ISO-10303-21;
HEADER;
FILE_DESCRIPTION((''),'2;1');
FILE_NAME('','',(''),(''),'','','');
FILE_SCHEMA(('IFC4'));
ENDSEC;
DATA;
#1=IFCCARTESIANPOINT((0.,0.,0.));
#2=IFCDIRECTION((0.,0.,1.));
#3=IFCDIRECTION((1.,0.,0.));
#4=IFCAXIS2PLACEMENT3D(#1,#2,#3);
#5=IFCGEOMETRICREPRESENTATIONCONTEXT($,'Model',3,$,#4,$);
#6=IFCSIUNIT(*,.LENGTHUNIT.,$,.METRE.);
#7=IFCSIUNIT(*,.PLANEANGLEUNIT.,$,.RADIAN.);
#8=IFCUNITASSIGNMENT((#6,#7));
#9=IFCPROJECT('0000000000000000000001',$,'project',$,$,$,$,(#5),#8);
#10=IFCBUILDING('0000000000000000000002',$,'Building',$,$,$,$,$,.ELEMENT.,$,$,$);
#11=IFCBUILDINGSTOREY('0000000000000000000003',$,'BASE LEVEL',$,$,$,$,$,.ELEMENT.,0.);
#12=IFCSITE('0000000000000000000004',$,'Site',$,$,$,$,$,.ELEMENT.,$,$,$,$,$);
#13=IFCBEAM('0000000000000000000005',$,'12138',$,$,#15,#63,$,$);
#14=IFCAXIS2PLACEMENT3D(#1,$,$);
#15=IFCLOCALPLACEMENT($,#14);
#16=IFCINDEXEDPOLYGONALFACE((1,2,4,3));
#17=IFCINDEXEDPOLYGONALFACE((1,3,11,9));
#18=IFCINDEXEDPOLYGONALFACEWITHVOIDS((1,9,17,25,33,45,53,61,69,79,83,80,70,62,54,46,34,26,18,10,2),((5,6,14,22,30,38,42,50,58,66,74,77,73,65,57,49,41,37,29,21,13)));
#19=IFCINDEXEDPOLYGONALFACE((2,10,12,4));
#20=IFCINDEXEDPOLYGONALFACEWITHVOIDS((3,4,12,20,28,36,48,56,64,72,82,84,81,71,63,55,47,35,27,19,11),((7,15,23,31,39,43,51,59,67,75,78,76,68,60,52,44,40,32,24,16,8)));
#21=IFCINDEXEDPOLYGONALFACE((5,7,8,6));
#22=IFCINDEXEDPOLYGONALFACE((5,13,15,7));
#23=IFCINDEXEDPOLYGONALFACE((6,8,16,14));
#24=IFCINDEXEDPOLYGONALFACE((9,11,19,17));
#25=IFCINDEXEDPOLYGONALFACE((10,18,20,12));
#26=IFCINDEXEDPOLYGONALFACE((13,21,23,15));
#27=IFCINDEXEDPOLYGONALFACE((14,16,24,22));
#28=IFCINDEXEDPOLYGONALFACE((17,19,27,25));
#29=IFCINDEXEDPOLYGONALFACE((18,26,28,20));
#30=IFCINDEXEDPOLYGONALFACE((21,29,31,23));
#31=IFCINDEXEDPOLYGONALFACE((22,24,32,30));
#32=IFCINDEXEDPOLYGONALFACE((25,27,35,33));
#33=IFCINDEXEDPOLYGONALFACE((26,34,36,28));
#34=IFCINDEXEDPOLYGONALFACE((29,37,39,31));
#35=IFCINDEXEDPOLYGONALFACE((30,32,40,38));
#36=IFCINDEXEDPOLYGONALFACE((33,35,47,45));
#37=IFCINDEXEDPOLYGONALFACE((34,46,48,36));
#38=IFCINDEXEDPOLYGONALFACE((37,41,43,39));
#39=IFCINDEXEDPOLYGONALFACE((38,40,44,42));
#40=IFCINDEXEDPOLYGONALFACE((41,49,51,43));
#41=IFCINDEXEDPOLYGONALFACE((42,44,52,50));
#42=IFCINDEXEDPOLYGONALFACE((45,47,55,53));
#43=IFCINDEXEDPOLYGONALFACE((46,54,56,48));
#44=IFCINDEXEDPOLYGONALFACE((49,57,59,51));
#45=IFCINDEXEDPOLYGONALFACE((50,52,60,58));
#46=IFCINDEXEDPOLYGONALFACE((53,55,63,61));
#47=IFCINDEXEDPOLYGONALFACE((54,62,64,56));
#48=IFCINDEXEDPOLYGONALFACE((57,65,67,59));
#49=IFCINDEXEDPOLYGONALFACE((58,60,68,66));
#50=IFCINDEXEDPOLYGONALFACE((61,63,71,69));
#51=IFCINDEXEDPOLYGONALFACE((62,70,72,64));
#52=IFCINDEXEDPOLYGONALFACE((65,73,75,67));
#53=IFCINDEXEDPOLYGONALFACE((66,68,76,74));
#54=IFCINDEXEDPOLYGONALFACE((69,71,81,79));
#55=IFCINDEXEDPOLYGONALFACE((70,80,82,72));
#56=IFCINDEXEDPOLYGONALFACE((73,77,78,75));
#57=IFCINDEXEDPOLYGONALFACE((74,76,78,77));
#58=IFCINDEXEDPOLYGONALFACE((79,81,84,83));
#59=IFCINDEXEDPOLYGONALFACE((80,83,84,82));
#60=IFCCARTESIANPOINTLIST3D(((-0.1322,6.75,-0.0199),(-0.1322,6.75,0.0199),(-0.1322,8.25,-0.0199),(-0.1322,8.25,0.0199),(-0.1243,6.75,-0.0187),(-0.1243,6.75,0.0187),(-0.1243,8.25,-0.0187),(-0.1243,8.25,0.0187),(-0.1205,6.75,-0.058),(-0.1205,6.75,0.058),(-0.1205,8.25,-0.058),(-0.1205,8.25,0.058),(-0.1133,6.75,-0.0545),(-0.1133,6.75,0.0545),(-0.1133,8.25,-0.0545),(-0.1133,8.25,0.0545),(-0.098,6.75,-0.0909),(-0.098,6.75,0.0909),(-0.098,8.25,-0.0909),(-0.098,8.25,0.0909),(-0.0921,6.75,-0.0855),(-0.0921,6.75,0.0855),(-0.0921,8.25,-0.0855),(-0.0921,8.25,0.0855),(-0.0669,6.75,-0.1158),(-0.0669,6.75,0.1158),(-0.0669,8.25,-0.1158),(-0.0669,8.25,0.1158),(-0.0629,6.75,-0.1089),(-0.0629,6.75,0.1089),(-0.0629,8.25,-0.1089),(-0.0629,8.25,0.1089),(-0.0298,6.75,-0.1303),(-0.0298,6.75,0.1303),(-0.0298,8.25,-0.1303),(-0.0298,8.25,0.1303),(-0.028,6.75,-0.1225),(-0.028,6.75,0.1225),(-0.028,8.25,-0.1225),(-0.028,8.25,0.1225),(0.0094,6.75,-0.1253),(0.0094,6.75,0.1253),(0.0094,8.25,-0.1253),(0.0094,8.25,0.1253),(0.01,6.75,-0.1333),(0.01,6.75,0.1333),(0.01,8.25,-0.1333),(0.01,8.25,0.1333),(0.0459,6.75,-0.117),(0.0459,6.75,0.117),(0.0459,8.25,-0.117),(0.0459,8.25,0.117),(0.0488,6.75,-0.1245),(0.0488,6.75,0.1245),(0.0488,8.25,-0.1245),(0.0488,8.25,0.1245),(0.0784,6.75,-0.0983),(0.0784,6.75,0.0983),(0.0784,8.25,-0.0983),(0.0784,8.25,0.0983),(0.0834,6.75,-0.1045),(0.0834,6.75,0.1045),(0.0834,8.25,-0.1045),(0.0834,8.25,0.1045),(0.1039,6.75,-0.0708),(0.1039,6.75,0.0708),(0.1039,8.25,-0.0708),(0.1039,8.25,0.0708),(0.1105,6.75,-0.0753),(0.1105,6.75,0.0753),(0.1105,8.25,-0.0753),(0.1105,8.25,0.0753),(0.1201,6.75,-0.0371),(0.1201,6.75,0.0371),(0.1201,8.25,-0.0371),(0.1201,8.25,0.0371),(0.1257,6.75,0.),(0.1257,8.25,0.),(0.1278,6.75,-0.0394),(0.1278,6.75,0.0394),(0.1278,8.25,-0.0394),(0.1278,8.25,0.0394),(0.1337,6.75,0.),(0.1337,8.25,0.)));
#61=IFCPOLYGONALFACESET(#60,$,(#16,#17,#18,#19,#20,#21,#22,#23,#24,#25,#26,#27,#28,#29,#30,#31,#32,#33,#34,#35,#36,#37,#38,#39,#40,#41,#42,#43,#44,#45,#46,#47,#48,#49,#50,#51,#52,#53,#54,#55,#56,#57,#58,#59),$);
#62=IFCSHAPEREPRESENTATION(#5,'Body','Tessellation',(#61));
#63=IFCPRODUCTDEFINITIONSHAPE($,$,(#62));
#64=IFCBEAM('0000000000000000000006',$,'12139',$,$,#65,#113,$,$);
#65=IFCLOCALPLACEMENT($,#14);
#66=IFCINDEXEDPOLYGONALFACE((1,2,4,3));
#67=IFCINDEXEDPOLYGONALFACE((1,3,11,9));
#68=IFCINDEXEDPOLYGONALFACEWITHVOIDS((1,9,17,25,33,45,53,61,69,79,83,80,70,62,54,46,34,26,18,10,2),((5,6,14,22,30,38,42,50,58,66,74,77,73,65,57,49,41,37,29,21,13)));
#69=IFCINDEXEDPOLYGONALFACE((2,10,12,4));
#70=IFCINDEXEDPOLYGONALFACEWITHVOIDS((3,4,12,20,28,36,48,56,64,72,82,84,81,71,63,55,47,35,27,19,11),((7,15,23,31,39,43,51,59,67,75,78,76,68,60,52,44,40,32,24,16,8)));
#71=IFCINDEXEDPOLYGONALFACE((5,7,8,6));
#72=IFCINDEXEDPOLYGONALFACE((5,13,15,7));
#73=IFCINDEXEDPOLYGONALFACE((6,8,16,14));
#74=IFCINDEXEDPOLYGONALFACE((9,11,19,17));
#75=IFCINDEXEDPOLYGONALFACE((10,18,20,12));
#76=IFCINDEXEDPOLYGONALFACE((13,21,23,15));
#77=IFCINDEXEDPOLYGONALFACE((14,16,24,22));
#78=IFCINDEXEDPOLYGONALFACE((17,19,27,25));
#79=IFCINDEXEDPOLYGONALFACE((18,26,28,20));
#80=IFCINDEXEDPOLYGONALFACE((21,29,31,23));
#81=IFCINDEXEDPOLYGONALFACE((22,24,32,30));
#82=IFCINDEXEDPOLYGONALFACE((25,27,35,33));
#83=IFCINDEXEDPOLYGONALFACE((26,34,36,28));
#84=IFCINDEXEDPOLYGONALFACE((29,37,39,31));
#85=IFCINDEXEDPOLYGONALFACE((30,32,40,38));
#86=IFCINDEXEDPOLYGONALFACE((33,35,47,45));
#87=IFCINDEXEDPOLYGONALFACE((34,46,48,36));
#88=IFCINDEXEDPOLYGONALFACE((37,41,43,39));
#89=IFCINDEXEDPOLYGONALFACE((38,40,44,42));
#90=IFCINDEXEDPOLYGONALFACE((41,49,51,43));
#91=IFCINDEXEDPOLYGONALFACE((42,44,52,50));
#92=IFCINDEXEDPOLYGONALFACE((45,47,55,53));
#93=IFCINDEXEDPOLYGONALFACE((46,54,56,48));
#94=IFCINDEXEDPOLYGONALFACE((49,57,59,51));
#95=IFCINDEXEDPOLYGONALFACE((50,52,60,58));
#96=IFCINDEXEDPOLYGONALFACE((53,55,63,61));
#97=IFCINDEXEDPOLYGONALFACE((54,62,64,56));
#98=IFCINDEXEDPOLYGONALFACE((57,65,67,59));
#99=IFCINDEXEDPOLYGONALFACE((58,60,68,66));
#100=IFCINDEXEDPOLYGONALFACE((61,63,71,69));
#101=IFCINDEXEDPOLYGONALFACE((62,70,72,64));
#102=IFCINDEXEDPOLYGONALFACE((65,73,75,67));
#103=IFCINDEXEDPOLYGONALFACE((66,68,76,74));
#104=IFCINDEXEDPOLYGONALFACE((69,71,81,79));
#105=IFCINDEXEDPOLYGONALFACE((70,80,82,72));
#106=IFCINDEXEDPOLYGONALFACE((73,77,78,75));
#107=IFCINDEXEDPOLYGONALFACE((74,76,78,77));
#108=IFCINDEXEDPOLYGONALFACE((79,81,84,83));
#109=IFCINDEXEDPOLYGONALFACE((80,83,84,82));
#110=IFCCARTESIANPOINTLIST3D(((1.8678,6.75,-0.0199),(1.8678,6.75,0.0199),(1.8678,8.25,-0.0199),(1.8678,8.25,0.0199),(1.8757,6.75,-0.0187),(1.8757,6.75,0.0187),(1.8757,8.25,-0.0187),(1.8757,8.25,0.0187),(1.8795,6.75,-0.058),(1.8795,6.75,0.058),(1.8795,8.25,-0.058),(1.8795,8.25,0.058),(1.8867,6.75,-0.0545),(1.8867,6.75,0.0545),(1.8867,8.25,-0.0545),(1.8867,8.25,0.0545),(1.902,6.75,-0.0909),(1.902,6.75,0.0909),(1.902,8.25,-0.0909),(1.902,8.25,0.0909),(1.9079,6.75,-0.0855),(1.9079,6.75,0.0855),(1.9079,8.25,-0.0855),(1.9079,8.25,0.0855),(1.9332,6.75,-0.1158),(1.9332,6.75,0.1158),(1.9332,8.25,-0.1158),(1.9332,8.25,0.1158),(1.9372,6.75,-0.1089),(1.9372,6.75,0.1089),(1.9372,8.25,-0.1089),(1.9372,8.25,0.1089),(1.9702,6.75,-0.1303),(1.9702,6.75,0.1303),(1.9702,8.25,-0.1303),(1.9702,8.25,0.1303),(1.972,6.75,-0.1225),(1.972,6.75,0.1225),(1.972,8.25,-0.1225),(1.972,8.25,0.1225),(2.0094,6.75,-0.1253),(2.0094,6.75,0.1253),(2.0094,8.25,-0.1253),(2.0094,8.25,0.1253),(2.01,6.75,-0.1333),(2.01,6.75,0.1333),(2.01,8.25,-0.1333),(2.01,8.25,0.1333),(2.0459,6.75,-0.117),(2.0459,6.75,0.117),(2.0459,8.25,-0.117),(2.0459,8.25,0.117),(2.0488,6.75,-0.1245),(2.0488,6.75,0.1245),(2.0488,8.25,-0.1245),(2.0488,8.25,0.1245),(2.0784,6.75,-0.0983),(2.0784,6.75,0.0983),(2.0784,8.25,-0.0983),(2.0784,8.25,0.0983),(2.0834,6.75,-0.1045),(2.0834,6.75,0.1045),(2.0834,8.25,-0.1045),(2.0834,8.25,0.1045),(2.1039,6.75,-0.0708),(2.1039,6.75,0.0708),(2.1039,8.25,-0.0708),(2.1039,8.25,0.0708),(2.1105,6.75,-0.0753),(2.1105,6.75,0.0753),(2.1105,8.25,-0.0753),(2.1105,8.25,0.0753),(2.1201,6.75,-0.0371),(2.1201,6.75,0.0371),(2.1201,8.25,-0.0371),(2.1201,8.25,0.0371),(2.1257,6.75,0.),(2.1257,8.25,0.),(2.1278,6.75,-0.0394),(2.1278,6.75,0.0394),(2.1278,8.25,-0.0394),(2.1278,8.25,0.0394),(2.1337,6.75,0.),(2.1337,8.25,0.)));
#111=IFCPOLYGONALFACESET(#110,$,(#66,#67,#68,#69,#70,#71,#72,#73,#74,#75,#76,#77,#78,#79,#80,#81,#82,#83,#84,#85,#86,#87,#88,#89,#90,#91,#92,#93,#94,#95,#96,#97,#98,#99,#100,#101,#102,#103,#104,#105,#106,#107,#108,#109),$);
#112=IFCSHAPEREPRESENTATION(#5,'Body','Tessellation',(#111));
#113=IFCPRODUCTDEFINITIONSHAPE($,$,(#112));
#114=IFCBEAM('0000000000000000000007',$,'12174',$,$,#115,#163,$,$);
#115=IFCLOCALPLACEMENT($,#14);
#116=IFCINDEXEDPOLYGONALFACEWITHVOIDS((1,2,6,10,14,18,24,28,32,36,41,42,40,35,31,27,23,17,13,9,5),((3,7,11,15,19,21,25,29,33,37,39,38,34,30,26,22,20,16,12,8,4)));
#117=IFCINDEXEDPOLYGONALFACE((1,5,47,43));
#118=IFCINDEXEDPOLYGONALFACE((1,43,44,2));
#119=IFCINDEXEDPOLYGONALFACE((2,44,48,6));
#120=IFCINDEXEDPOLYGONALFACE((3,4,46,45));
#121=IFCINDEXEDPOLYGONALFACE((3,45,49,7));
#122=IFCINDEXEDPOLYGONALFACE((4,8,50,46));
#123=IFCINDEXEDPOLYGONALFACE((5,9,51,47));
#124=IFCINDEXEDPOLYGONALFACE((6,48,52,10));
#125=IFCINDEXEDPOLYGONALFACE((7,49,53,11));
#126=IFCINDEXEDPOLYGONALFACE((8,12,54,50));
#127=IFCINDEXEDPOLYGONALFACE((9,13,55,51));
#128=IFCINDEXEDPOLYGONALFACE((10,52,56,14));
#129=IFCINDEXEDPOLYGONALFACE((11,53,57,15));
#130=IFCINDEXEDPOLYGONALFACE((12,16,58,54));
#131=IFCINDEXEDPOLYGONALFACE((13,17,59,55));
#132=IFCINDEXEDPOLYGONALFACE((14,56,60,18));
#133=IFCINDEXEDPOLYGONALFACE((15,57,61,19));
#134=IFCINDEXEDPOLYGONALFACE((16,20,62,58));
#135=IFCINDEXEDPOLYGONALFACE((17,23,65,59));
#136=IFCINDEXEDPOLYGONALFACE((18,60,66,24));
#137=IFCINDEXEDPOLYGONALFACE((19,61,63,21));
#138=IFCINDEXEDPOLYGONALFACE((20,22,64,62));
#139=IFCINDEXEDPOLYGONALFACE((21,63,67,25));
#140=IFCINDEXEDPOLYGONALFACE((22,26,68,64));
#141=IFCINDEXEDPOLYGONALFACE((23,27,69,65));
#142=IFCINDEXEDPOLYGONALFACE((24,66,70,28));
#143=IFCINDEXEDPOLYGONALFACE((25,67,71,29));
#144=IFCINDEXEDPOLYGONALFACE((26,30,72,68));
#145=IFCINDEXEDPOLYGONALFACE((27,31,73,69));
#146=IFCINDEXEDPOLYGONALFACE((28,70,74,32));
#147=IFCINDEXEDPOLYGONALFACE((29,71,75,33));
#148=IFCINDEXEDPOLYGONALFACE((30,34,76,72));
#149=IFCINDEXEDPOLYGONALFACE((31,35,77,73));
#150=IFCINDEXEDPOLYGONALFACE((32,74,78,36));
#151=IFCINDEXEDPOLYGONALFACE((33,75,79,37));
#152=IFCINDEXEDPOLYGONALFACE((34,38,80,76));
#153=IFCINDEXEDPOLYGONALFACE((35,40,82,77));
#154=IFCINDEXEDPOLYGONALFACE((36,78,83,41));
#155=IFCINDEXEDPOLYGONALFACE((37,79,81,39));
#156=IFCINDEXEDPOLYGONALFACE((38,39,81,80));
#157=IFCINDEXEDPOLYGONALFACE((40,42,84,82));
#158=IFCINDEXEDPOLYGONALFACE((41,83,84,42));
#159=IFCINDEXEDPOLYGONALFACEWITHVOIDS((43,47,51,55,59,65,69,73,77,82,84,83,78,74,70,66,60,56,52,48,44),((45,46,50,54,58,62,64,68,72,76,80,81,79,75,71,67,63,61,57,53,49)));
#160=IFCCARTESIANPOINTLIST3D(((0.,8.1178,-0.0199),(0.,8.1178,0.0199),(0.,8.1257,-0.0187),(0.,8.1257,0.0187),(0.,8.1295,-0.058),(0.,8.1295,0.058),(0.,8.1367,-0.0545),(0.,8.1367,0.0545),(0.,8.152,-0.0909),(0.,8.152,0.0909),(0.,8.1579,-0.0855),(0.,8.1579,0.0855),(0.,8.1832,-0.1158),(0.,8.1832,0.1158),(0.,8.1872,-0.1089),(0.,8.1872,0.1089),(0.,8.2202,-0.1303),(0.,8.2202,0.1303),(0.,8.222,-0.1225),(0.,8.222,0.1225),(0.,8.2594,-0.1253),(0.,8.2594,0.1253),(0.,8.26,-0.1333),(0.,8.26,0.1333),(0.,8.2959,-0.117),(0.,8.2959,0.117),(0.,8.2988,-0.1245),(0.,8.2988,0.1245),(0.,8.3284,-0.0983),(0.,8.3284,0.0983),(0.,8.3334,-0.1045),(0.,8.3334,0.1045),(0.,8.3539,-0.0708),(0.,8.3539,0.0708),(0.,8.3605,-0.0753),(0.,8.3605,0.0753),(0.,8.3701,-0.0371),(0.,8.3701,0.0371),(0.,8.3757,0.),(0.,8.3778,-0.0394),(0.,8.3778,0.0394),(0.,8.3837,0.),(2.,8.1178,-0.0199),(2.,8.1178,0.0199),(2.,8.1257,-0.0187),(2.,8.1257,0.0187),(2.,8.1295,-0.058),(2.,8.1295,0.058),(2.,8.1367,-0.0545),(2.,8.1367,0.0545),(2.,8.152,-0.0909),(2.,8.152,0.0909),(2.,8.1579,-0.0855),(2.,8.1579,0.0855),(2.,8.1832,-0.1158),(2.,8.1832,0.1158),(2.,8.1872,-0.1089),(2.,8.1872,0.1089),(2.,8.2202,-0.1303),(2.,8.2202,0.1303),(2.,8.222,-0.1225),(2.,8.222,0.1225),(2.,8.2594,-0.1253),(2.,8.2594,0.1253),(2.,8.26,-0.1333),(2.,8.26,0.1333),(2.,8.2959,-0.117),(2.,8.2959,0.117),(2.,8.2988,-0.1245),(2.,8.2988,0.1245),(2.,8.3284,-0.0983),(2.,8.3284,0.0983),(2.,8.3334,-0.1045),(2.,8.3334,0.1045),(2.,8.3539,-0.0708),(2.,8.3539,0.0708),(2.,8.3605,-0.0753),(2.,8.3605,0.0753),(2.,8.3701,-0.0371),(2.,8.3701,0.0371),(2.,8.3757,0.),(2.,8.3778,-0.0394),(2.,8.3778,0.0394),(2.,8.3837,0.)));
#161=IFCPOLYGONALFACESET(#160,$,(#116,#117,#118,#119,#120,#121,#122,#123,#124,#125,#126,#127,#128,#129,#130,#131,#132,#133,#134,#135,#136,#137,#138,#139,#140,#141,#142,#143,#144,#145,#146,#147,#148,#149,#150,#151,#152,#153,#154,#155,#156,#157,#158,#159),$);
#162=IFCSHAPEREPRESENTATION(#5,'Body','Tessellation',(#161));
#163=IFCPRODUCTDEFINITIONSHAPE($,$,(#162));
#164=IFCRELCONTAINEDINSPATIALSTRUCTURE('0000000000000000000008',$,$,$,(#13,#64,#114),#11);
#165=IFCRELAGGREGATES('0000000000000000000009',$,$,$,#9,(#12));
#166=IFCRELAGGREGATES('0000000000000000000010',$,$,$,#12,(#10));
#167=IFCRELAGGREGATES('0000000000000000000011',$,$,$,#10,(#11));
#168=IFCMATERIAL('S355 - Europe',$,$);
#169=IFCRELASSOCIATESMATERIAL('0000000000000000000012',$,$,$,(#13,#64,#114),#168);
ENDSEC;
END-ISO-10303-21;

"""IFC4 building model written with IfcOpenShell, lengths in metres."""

from ifc_helpers import new_model, si_unit, frame, origin_with_axes, origin_2d_with_axis, place, context, project, spatial, hollow_circle, extrude, material, material_profile, profile_set, profile_usage, element, save


model = new_model("IFC4")

# Units and contexts
model_context = context("Model", 3, world=origin_with_axes())
ifc_project = project(units=[si_unit("LENGTHUNIT", "METRE"), si_unit("PLANEANGLEUNIT", "RADIAN")], contexts=[model_context])

# Site, building, storey
site = spatial("IfcSite", under=ifc_project, Name="Site", CompositionType="ELEMENT")
building = spatial("IfcBuilding", under=site, Name="Building", CompositionType="ELEMENT")
storey = spatial("IfcBuildingStorey", under=building, Name="BASE LEVEL", CompositionType="ELEMENT", Elevation=0.0)

# Shared definitions
ifc_material = material(Name="S355 - Europe")

# Beams
ifc_material_profile_1 = material_profile(ifc_material, hollow_circle(Radius=0.1337, WallThickness=0.008, at=origin_2d_with_axis()))
ifc_profile_set_1 = profile_set([ifc_material_profile_1])
ifc_profile_usage_1 = profile_usage(ifc_profile_set_1, cardinal=10)
beam_1_placement = place(None, frame((0.0, 8.25, 0.0), z_axis=(0.0, -1.0, 0.0), x_axis=(1.0, 0.0, 0.0)))
element("IfcBeam", 1, at=beam_1_placement, inside=storey, material=ifc_profile_usage_1, Name="12138", context=model_context, shape_type="SweptSolid", body=[
    extrude(hollow_circle(Radius=0.1337, WallThickness=0.008, at=origin_2d_with_axis()), origin_with_axes(), (0.0, 0.0, 1.0), 1.5),
])
ifc_material_profile_2 = material_profile(ifc_material, hollow_circle(Radius=0.1337, WallThickness=0.008, at=origin_2d_with_axis()))
ifc_profile_set_2 = profile_set([ifc_material_profile_2])
ifc_profile_usage_2 = profile_usage(ifc_profile_set_2, cardinal=10)
beam_2_placement = place(None, frame((2.0, 8.25, 0.0), z_axis=(0.0, -1.0, 0.0), x_axis=(1.0, 0.0, 0.0)))
element("IfcBeam", 2, at=beam_2_placement, inside=storey, material=ifc_profile_usage_2, Name="12139", context=model_context, shape_type="SweptSolid", body=[
    extrude(hollow_circle(Radius=0.1337, WallThickness=0.008, at=origin_2d_with_axis()), origin_with_axes(), (0.0, 0.0, 1.0), 1.5),
])
ifc_material_profile_3 = material_profile(ifc_material, hollow_circle(Radius=0.1337, WallThickness=0.008, at=origin_2d_with_axis()))
ifc_profile_set_3 = profile_set([ifc_material_profile_3])
ifc_profile_usage_3 = profile_usage(ifc_profile_set_3, cardinal=10)
beam_3_placement = place(None, frame((0.0, 8.25, 0.0), z_axis=(1.0, 0.0, 0.0), x_axis=(0.0, 1.0, 0.0)))
element("IfcBeam", 3, at=beam_3_placement, inside=storey, material=ifc_profile_usage_3, Name="12174", context=model_context, shape_type="SweptSolid", body=[
    extrude(hollow_circle(Radius=0.1337, WallThickness=0.008, at=origin_2d_with_axis()), origin_with_axes(), (0.0, 0.0, 1.0), 2.0),
])

save(model, "model.ifc")
